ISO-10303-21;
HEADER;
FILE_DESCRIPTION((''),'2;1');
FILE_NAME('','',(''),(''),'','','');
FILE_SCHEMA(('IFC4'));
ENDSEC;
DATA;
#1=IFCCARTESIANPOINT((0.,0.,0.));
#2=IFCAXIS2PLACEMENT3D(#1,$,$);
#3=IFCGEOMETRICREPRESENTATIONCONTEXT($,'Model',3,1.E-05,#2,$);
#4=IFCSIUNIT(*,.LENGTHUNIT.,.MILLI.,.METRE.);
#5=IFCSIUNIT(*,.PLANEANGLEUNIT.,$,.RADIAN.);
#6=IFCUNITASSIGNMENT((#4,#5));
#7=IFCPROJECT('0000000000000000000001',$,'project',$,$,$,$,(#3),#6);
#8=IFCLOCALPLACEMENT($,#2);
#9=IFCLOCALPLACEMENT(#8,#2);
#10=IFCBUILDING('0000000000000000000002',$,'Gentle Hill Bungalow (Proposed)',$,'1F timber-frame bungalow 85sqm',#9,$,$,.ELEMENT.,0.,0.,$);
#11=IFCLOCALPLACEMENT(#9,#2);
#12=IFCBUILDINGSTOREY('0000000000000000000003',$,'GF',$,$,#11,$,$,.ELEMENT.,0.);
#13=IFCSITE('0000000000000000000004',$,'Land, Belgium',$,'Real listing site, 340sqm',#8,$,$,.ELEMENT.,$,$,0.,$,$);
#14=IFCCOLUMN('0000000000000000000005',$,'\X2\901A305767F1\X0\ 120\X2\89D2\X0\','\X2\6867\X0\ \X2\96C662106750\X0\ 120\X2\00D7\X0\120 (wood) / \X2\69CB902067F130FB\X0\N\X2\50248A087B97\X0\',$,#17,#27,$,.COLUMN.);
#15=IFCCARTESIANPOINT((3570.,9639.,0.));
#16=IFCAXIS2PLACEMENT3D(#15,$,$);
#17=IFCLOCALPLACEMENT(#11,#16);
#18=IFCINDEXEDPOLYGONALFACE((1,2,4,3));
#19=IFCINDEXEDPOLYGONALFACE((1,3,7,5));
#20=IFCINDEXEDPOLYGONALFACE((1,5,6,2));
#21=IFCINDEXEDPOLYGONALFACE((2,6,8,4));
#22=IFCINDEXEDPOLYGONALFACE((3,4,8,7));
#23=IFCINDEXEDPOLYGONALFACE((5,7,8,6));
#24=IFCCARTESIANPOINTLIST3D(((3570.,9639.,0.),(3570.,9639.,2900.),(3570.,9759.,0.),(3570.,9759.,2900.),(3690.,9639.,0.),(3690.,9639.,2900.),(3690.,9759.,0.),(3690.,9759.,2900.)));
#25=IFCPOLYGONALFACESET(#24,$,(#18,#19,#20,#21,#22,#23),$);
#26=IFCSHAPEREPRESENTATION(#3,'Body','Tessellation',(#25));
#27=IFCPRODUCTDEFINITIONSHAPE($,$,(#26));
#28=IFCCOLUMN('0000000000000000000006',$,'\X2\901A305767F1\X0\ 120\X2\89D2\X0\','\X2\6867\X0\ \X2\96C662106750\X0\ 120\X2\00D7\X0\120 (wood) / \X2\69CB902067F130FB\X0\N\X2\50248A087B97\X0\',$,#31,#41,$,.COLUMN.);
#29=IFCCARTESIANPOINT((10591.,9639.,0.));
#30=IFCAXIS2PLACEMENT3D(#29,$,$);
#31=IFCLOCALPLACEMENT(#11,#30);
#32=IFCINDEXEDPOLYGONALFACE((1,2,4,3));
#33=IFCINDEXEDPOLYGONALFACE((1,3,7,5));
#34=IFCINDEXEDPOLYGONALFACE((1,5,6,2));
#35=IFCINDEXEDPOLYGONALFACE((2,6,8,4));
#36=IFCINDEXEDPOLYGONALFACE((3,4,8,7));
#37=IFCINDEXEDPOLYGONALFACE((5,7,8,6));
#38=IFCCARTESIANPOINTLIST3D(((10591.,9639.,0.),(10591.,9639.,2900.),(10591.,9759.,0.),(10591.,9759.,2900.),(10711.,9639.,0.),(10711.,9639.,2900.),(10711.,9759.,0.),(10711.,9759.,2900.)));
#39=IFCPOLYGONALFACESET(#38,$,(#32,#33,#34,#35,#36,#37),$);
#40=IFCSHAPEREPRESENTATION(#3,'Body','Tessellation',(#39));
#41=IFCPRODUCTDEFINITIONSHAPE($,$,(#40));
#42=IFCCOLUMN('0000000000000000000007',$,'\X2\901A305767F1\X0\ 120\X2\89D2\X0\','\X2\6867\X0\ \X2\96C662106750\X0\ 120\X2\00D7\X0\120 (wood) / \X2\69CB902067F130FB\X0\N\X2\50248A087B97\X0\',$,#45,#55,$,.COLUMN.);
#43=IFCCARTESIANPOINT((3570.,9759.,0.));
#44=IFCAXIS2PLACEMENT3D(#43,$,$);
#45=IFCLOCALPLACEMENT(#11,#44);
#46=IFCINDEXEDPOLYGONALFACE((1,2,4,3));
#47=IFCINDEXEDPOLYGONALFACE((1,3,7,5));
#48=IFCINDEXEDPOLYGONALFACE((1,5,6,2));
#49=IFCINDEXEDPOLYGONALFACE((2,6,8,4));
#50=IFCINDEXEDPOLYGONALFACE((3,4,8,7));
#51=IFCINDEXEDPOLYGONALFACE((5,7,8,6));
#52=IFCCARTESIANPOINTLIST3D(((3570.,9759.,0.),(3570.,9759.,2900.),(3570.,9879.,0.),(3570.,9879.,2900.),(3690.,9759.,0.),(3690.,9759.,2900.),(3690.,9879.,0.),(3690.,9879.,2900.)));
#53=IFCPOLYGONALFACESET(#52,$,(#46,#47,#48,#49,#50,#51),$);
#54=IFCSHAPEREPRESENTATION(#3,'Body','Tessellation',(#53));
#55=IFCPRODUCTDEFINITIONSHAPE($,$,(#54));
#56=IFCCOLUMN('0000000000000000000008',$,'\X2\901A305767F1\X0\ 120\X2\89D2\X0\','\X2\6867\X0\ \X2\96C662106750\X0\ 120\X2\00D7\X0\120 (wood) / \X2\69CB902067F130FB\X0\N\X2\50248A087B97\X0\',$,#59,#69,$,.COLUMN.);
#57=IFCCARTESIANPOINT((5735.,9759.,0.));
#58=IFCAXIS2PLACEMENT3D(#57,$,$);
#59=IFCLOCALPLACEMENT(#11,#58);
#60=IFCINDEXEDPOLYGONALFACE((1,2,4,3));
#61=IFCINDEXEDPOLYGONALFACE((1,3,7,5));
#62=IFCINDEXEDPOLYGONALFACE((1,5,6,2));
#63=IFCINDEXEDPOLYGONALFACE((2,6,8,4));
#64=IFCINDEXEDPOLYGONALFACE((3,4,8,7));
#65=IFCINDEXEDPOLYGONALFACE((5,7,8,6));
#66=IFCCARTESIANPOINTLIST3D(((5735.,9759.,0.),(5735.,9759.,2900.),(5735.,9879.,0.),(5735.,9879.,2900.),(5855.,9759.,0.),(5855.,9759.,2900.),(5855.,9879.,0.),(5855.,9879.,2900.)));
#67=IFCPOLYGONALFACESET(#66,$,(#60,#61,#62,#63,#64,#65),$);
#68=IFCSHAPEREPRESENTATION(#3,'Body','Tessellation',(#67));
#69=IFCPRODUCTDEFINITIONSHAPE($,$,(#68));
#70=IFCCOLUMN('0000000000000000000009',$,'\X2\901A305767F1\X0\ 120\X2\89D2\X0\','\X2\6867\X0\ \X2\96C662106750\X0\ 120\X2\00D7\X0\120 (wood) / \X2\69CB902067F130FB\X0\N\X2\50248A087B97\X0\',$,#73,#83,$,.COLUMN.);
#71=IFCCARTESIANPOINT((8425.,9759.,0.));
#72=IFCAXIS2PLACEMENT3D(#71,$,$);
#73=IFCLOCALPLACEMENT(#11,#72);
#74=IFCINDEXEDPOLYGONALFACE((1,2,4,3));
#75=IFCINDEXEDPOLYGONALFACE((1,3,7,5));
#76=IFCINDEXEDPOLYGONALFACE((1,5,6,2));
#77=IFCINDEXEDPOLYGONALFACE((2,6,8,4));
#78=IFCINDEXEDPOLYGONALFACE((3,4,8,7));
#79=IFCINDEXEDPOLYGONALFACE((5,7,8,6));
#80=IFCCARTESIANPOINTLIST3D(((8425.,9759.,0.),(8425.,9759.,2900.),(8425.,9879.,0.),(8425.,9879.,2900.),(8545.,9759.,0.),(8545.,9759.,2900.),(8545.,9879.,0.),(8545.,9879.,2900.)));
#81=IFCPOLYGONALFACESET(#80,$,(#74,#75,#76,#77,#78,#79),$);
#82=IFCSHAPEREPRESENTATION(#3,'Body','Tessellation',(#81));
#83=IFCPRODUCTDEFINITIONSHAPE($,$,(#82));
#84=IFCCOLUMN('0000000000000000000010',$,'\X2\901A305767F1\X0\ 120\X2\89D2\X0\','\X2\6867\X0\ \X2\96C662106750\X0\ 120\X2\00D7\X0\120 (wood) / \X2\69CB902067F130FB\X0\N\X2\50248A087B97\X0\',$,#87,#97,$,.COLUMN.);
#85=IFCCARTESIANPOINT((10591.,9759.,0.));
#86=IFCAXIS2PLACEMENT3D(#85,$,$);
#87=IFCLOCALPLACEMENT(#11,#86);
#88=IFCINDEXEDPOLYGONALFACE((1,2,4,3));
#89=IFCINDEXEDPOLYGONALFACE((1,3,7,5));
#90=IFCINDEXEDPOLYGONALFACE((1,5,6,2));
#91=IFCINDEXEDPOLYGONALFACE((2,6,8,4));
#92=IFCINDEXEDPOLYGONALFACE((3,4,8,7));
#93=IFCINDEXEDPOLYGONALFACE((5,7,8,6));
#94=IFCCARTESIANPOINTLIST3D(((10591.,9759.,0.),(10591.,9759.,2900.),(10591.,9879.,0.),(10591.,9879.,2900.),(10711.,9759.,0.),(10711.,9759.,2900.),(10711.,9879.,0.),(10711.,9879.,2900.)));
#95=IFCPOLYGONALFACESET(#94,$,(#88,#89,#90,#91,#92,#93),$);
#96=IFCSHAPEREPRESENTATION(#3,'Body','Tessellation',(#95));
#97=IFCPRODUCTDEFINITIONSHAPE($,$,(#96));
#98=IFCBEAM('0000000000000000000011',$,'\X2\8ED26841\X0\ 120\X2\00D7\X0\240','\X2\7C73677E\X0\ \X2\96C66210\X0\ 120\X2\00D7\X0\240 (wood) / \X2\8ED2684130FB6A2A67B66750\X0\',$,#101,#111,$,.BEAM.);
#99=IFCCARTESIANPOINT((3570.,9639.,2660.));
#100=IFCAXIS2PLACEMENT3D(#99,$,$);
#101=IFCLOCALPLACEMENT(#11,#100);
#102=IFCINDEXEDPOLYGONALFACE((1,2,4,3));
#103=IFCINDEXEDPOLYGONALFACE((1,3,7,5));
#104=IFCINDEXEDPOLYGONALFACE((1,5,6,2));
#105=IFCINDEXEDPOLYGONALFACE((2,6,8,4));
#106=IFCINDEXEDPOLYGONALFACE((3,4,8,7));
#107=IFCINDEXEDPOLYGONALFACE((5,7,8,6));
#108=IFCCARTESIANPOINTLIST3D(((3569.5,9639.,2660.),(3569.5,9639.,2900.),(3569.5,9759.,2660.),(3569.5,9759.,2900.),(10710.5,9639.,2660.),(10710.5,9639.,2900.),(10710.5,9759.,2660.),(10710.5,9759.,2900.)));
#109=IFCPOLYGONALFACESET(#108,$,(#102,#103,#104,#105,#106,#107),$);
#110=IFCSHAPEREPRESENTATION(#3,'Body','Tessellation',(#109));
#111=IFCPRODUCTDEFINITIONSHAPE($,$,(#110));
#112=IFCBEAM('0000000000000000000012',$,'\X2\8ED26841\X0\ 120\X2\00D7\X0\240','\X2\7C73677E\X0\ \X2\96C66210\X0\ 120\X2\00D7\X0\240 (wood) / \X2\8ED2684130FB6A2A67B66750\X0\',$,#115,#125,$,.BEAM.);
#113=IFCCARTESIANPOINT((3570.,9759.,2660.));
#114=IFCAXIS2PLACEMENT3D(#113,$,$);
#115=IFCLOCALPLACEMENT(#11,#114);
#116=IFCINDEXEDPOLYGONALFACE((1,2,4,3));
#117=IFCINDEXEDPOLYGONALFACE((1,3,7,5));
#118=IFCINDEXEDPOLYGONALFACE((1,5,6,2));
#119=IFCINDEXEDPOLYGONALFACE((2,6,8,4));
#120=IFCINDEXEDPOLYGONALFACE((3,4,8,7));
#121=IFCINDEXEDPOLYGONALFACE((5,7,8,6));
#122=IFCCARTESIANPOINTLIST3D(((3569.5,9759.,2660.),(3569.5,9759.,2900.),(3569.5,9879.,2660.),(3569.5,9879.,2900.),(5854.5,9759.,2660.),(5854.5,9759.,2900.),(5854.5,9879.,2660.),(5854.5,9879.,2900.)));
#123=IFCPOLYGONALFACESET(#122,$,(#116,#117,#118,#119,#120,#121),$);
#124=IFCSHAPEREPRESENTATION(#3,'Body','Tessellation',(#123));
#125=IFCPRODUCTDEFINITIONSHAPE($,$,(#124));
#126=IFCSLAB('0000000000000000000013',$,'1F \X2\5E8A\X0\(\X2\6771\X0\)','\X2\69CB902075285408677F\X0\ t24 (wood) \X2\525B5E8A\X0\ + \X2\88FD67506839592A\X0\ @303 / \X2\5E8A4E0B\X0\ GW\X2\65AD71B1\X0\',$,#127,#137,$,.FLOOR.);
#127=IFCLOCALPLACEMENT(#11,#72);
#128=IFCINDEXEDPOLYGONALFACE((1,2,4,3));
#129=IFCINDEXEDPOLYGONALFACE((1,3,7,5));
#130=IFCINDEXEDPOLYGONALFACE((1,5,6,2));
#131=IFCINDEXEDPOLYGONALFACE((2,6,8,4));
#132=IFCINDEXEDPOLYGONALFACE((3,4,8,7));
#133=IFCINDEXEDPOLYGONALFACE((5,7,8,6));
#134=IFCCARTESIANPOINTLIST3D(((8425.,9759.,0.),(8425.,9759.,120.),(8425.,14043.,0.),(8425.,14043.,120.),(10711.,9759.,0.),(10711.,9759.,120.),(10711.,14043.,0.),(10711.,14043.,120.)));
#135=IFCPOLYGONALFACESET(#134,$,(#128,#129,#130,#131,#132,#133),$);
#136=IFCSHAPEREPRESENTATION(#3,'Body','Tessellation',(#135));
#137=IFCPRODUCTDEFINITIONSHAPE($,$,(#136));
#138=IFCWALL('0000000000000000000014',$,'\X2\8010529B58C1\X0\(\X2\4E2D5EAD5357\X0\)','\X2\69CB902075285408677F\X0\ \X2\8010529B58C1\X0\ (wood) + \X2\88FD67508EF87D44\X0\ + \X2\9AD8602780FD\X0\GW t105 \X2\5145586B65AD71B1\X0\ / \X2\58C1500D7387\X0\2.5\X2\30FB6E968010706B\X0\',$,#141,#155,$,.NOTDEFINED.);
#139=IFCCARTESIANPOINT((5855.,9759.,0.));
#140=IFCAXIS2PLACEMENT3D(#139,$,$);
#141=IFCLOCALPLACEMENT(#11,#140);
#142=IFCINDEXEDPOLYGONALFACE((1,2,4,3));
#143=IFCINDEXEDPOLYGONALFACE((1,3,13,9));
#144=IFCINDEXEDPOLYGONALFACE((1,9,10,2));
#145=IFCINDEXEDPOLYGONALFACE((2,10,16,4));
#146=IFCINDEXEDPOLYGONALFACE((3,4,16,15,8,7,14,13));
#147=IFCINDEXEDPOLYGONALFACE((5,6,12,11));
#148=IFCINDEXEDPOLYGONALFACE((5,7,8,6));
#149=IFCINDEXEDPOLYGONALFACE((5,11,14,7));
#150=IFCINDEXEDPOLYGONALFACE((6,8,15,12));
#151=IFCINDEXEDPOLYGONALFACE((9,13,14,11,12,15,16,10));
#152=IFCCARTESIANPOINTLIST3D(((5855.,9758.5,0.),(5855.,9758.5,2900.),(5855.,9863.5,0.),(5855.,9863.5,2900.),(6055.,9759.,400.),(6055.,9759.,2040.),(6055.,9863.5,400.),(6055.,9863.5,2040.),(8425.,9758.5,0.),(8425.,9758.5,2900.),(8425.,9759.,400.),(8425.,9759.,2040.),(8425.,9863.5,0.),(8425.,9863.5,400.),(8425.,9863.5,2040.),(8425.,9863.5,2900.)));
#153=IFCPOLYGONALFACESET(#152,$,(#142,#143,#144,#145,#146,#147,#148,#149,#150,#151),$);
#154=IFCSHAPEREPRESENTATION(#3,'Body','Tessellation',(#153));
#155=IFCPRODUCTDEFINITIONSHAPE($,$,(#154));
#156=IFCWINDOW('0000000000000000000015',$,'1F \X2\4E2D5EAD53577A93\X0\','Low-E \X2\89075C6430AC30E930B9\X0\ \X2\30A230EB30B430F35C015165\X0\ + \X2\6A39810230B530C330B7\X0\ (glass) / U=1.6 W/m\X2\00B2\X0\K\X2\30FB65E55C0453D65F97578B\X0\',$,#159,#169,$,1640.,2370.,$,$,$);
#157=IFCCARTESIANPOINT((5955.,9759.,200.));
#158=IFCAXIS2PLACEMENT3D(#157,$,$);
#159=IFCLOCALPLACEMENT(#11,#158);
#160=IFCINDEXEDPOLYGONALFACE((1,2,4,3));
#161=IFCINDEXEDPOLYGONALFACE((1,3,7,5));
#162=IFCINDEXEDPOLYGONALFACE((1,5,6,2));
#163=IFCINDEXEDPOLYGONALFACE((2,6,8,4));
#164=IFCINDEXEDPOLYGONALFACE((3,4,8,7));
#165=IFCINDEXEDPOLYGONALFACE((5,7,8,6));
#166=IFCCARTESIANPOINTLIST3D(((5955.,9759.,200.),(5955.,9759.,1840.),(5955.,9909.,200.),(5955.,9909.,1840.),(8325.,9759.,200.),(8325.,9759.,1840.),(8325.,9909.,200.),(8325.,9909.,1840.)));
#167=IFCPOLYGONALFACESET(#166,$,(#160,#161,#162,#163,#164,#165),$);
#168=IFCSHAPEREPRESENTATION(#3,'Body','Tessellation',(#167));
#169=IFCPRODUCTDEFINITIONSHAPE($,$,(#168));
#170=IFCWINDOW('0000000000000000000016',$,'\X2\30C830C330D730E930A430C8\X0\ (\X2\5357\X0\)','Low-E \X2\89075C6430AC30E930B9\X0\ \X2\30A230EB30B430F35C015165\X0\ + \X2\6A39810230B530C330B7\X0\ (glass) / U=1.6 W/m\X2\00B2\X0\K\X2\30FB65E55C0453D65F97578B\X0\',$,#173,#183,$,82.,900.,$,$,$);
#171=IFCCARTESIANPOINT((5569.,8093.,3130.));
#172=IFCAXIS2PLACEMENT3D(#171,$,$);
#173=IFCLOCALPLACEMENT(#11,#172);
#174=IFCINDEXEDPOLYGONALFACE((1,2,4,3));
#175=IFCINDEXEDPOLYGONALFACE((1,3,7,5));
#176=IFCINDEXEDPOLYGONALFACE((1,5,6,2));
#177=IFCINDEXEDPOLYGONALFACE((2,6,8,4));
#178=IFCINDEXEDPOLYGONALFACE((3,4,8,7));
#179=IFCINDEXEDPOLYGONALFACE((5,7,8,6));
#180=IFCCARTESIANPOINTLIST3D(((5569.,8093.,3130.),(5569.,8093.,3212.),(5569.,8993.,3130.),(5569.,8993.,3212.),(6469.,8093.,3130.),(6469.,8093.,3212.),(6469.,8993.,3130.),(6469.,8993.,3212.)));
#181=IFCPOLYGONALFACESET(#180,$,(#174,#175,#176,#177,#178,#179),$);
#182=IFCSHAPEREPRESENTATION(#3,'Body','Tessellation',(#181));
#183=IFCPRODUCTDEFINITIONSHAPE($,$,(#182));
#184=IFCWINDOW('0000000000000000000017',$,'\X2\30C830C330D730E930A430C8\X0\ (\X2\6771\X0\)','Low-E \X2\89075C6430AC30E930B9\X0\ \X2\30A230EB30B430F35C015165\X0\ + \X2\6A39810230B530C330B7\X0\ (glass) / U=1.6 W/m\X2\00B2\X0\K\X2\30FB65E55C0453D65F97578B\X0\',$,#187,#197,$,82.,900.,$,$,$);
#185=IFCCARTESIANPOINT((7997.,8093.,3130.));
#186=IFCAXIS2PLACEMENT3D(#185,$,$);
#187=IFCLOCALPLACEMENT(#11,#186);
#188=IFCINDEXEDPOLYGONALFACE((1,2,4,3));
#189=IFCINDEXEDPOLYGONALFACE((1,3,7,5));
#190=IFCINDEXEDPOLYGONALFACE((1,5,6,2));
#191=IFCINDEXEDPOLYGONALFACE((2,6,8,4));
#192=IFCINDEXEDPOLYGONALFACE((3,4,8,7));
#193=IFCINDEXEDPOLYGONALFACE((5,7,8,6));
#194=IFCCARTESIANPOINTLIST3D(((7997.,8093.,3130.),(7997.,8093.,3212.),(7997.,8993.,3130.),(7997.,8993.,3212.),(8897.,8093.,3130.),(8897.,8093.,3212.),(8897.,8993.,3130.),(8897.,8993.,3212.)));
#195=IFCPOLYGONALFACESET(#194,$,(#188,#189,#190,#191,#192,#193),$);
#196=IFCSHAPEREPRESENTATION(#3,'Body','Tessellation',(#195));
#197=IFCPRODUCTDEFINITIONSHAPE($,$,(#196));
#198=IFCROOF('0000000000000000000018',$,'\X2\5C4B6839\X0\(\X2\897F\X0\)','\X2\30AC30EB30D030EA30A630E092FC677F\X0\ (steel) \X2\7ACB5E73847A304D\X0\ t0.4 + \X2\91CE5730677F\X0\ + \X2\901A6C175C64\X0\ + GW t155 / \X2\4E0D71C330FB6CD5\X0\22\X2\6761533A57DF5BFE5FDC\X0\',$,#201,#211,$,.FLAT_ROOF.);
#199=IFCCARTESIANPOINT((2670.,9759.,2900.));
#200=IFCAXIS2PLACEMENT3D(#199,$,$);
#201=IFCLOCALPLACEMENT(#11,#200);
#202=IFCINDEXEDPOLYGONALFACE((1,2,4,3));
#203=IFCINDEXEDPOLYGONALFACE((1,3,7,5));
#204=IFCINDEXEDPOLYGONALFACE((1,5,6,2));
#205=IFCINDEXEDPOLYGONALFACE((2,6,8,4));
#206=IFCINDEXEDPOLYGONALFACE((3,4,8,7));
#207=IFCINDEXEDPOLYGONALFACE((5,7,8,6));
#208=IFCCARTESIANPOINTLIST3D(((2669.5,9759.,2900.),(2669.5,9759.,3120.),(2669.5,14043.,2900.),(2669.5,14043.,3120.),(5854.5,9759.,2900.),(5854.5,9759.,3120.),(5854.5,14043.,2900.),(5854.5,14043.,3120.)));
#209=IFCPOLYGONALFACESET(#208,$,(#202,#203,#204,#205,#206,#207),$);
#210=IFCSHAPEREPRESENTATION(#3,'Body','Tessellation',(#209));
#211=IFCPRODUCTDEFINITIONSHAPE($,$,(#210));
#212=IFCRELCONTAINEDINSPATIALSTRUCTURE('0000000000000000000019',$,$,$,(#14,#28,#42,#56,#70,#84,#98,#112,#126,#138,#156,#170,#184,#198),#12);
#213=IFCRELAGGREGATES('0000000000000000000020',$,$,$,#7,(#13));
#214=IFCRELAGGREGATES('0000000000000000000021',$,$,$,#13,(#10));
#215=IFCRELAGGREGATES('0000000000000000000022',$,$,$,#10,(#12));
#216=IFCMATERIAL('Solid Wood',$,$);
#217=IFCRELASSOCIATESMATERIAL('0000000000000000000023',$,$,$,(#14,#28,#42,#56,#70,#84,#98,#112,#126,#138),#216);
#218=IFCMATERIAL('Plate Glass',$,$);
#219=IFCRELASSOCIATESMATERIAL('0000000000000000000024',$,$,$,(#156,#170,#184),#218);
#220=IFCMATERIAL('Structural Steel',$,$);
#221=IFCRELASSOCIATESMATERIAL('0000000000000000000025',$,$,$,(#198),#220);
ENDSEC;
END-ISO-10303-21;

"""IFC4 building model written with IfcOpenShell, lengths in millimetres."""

from ifc_helpers import new_model, si_unit, frame, frame_2d, origin, place, context, project, spatial, rectangle, extrude, material, element, fill, save


model = new_model("IFC4")

# Units and contexts
model_context = context("Model", 3, precision=1e-05, world=origin())
ifc_project = project(units=[si_unit("LENGTHUNIT", "METRE", prefix="MILLI"), si_unit("PLANEANGLEUNIT", "RADIAN")], contexts=[model_context])

# Site, building, storey
site_placement = place(None, origin())
site = spatial("IfcSite", under=ifc_project, at=site_placement, Name="Land, Belgium", ObjectType="Real listing site, 340sqm", CompositionType="ELEMENT", RefElevation=0.0)
building_placement = place(site_placement, origin())
building = spatial("IfcBuilding", under=site, at=building_placement, Name="Gentle Hill Bungalow (Proposed)", ObjectType="1F timber-frame bungalow 85sqm", CompositionType="ELEMENT", ElevationOfRefHeight=0.0, ElevationOfTerrain=0.0)
storey_placement = place(building_placement, origin())
storey = spatial("IfcBuildingStorey", under=building, at=storey_placement, Name="GF", CompositionType="ELEMENT", Elevation=0.0)

# Columns
ifc_material_1 = material(Name="Solid Wood")
column_1_placement = place(storey_placement, frame((3570.0, 9639.0, 0.0)))
element("IfcColumn", 1, at=column_1_placement, inside=storey, material=ifc_material_1, Name="通し柱 120角", Description="桧 集成材 120×120 (wood) / 構造柱・N値計算", PredefinedType="COLUMN", context=model_context, shape_type="SweptSolid", body=[
    extrude(rectangle(XDim=120.0, YDim=120.0, at=frame_2d((60.0, 60.0))), frame((3570.0, 9639.0, 0.0)), (0.0, 0.0, 1.0), 2900.0),
])
column_2_placement = place(storey_placement, frame((10591.0, 9639.0, 0.0)))
element("IfcColumn", 2, at=column_2_placement, inside=storey, material=ifc_material_1, Name="通し柱 120角", Description="桧 集成材 120×120 (wood) / 構造柱・N値計算", PredefinedType="COLUMN", context=model_context, shape_type="SweptSolid", body=[
    extrude(rectangle(XDim=120.0, YDim=120.0, at=frame_2d((60.0, 60.0))), frame((10591.0, 9639.0, 0.0)), (0.0, 0.0, 1.0), 2900.0),
])
column_3_placement = place(storey_placement, frame((3570.0, 9759.0, 0.0)))
element("IfcColumn", 3, at=column_3_placement, inside=storey, material=ifc_material_1, Name="通し柱 120角", Description="桧 集成材 120×120 (wood) / 構造柱・N値計算", PredefinedType="COLUMN", context=model_context, shape_type="SweptSolid", body=[
    extrude(rectangle(XDim=120.0, YDim=120.0, at=frame_2d((60.0, 60.0))), frame((3570.0, 9759.0, 0.0)), (0.0, 0.0, 1.0), 2900.0),
])
column_4_placement = place(storey_placement, frame((5735.0, 9759.0, 0.0)))
element("IfcColumn", 4, at=column_4_placement, inside=storey, material=ifc_material_1, Name="通し柱 120角", Description="桧 集成材 120×120 (wood) / 構造柱・N値計算", PredefinedType="COLUMN", context=model_context, shape_type="SweptSolid", body=[
    extrude(rectangle(XDim=120.0, YDim=120.0, at=frame_2d((60.0, 60.0))), frame((5735.0, 9759.0, 0.0)), (0.0, 0.0, 1.0), 2900.0),
])
column_5_placement = place(storey_placement, frame((8425.0, 9759.0, 0.0)))
element("IfcColumn", 5, at=column_5_placement, inside=storey, material=ifc_material_1, Name="通し柱 120角", Description="桧 集成材 120×120 (wood) / 構造柱・N値計算", PredefinedType="COLUMN", context=model_context, shape_type="SweptSolid", body=[
    extrude(rectangle(XDim=120.0, YDim=120.0, at=frame_2d((60.0, 60.0))), frame((8425.0, 9759.0, 0.0)), (0.0, 0.0, 1.0), 2900.0),
])
column_6_placement = place(storey_placement, frame((10591.0, 9759.0, 0.0)))
element("IfcColumn", 6, at=column_6_placement, inside=storey, material=ifc_material_1, Name="通し柱 120角", Description="桧 集成材 120×120 (wood) / 構造柱・N値計算", PredefinedType="COLUMN", context=model_context, shape_type="SweptSolid", body=[
    extrude(rectangle(XDim=120.0, YDim=120.0, at=frame_2d((60.0, 60.0))), frame((10591.0, 9759.0, 0.0)), (0.0, 0.0, 1.0), 2900.0),
])

# Beams
beam_1_placement = place(storey_placement, frame((3570.0, 9639.0, 2660.0)))
element("IfcBeam", 7, at=beam_1_placement, inside=storey, material=ifc_material_1, Name="軒桁 120×240", Description="米松 集成 120×240 (wood) / 軒桁・横架材", PredefinedType="BEAM", context=model_context, shape_type="SweptSolid", body=[
    extrude(rectangle(XDim=7141.0, YDim=120.0, at=frame_2d((3570.0, 60.0))), frame((3570.0, 9639.0, 2660.0)), (0.0, 0.0, 1.0), 240.0),
])
beam_2_placement = place(storey_placement, frame((3570.0, 9759.0, 2660.0)))
element("IfcBeam", 8, at=beam_2_placement, inside=storey, material=ifc_material_1, Name="軒桁 120×240", Description="米松 集成 120×240 (wood) / 軒桁・横架材", PredefinedType="BEAM", context=model_context, shape_type="SweptSolid", body=[
    extrude(rectangle(XDim=2285.0, YDim=120.0, at=frame_2d((1142.0, 60.0))), frame((3570.0, 9759.0, 2660.0)), (0.0, 0.0, 1.0), 240.0),
])

# Slab
slab_1_placement = place(storey_placement, frame((8425.0, 9759.0, 0.0)))
element("IfcSlab", 9, at=slab_1_placement, inside=storey, material=ifc_material_1, Name="1F 床(東)", Description="構造用合板 t24 (wood) 剛床 + 製材根太 @303 / 床下 GW断熱", PredefinedType="FLOOR", context=model_context, shape_type="SweptSolid", body=[
    extrude(rectangle(XDim=2286.0, YDim=4284.0, at=frame_2d((1143.0, 2142.0))), frame((8425.0, 9759.0, 0.0)), (0.0, 0.0, 1.0), 120.0),
])

# Wall, opening, window
wall_1_placement = place(storey_placement, frame((5855.0, 9759.0, 0.0)))
wall_1 = element("IfcWall", 10, at=wall_1_placement, inside=storey, material=ifc_material_1, Name="耐力壁(中庭南)", Description="構造用合板 耐力壁 (wood) + 製材軸組 + 高性能GW t105 充填断熱 / 壁倍率2.5・準耐火", PredefinedType="NOTDEFINED", context=model_context, shape_type="SweptSolid", body=[
    extrude(rectangle(XDim=2570.0, YDim=105.0, at=frame_2d((1285.0, 52.0))), frame((5855.0, 9759.0, 0.0)), (0.0, 0.0, 1.0), 2900.0),
])
opening_placement = place(storey_placement, frame((5955.0, 9759.0, 200.0)))
opening = element("IfcOpeningElement", 11, at=opening_placement, cuts=wall_1, PredefinedType="NOTDEFINED", context=model_context, shape_type="SweptSolid", body=[
    extrude(rectangle(XDim=2370.0, YDim=150.0, at=frame_2d((1185.0, 75.0))), frame((5955.0, 9759.0, 200.0)), (0.0, 0.0, 1.0), 1640.0),
])
ifc_material_2 = material(Name="Plate Glass")
window_1_placement = place(storey_placement, frame((5955.0, 9759.0, 200.0)))
window_1 = element("IfcWindow", 12, at=window_1_placement, inside=storey, material=ifc_material_2, Name="1F 中庭南窓", Description="Low-E 複層ガラス アルゴン封入 + 樹脂サッシ (glass) / U=1.6 W/m²K・日射取得型", OverallHeight=1640.0, OverallWidth=2370.0, context=model_context, shape_type="SweptSolid", body=[
    extrude(rectangle(XDim=2370.0, YDim=150.0, at=frame_2d((1185.0, 75.0))), frame((5955.0, 9759.0, 200.0)), (0.0, 0.0, 1.0), 1640.0),
])
fill(opening, window_1)

# Windows
window_2_placement = place(storey_placement, frame((5569.0, 8093.0, 3130.0)))
element("IfcWindow", 13, at=window_2_placement, inside=storey, material=ifc_material_2, Name="トップライト (南)", Description="Low-E 複層ガラス アルゴン封入 + 樹脂サッシ (glass) / U=1.6 W/m²K・日射取得型", OverallHeight=82.0, OverallWidth=900.0, context=model_context, shape_type="SweptSolid", body=[
    extrude(rectangle(XDim=900.0, YDim=900.0, at=frame_2d((450.0, 450.0))), frame((5569.0, 8093.0, 3130.0)), (0.0, 0.0, 1.0), 82.0),
])
window_3_placement = place(storey_placement, frame((7997.0, 8093.0, 3130.0)))
element("IfcWindow", 14, at=window_3_placement, inside=storey, material=ifc_material_2, Name="トップライト (東)", Description="Low-E 複層ガラス アルゴン封入 + 樹脂サッシ (glass) / U=1.6 W/m²K・日射取得型", OverallHeight=82.0, OverallWidth=900.0, context=model_context, shape_type="SweptSolid", body=[
    extrude(rectangle(XDim=900.0, YDim=900.0, at=frame_2d((450.0, 450.0))), frame((7997.0, 8093.0, 3130.0)), (0.0, 0.0, 1.0), 82.0),
])

# Roof
ifc_material_3 = material(Name="Structural Steel")
roof_1_placement = place(storey_placement, frame((2670.0, 9759.0, 2900.0)))
element("IfcRoof", 15, at=roof_1_placement, inside=storey, material=ifc_material_3, Name="屋根(西)", Description="ガルバリウム鋼板 (steel) 立平葺き t0.4 + 野地板 + 通気層 + GW t155 / 不燃・法22条区域対応", PredefinedType="FLAT_ROOF", context=model_context, shape_type="SweptSolid", body=[
    extrude(rectangle(XDim=3185.0, YDim=4284.0, at=frame_2d((1592.0, 2142.0))), frame((2670.0, 9759.0, 2900.0)), (0.0, 0.0, 1.0), 220.0),
])

save(model, "model.ifc")
